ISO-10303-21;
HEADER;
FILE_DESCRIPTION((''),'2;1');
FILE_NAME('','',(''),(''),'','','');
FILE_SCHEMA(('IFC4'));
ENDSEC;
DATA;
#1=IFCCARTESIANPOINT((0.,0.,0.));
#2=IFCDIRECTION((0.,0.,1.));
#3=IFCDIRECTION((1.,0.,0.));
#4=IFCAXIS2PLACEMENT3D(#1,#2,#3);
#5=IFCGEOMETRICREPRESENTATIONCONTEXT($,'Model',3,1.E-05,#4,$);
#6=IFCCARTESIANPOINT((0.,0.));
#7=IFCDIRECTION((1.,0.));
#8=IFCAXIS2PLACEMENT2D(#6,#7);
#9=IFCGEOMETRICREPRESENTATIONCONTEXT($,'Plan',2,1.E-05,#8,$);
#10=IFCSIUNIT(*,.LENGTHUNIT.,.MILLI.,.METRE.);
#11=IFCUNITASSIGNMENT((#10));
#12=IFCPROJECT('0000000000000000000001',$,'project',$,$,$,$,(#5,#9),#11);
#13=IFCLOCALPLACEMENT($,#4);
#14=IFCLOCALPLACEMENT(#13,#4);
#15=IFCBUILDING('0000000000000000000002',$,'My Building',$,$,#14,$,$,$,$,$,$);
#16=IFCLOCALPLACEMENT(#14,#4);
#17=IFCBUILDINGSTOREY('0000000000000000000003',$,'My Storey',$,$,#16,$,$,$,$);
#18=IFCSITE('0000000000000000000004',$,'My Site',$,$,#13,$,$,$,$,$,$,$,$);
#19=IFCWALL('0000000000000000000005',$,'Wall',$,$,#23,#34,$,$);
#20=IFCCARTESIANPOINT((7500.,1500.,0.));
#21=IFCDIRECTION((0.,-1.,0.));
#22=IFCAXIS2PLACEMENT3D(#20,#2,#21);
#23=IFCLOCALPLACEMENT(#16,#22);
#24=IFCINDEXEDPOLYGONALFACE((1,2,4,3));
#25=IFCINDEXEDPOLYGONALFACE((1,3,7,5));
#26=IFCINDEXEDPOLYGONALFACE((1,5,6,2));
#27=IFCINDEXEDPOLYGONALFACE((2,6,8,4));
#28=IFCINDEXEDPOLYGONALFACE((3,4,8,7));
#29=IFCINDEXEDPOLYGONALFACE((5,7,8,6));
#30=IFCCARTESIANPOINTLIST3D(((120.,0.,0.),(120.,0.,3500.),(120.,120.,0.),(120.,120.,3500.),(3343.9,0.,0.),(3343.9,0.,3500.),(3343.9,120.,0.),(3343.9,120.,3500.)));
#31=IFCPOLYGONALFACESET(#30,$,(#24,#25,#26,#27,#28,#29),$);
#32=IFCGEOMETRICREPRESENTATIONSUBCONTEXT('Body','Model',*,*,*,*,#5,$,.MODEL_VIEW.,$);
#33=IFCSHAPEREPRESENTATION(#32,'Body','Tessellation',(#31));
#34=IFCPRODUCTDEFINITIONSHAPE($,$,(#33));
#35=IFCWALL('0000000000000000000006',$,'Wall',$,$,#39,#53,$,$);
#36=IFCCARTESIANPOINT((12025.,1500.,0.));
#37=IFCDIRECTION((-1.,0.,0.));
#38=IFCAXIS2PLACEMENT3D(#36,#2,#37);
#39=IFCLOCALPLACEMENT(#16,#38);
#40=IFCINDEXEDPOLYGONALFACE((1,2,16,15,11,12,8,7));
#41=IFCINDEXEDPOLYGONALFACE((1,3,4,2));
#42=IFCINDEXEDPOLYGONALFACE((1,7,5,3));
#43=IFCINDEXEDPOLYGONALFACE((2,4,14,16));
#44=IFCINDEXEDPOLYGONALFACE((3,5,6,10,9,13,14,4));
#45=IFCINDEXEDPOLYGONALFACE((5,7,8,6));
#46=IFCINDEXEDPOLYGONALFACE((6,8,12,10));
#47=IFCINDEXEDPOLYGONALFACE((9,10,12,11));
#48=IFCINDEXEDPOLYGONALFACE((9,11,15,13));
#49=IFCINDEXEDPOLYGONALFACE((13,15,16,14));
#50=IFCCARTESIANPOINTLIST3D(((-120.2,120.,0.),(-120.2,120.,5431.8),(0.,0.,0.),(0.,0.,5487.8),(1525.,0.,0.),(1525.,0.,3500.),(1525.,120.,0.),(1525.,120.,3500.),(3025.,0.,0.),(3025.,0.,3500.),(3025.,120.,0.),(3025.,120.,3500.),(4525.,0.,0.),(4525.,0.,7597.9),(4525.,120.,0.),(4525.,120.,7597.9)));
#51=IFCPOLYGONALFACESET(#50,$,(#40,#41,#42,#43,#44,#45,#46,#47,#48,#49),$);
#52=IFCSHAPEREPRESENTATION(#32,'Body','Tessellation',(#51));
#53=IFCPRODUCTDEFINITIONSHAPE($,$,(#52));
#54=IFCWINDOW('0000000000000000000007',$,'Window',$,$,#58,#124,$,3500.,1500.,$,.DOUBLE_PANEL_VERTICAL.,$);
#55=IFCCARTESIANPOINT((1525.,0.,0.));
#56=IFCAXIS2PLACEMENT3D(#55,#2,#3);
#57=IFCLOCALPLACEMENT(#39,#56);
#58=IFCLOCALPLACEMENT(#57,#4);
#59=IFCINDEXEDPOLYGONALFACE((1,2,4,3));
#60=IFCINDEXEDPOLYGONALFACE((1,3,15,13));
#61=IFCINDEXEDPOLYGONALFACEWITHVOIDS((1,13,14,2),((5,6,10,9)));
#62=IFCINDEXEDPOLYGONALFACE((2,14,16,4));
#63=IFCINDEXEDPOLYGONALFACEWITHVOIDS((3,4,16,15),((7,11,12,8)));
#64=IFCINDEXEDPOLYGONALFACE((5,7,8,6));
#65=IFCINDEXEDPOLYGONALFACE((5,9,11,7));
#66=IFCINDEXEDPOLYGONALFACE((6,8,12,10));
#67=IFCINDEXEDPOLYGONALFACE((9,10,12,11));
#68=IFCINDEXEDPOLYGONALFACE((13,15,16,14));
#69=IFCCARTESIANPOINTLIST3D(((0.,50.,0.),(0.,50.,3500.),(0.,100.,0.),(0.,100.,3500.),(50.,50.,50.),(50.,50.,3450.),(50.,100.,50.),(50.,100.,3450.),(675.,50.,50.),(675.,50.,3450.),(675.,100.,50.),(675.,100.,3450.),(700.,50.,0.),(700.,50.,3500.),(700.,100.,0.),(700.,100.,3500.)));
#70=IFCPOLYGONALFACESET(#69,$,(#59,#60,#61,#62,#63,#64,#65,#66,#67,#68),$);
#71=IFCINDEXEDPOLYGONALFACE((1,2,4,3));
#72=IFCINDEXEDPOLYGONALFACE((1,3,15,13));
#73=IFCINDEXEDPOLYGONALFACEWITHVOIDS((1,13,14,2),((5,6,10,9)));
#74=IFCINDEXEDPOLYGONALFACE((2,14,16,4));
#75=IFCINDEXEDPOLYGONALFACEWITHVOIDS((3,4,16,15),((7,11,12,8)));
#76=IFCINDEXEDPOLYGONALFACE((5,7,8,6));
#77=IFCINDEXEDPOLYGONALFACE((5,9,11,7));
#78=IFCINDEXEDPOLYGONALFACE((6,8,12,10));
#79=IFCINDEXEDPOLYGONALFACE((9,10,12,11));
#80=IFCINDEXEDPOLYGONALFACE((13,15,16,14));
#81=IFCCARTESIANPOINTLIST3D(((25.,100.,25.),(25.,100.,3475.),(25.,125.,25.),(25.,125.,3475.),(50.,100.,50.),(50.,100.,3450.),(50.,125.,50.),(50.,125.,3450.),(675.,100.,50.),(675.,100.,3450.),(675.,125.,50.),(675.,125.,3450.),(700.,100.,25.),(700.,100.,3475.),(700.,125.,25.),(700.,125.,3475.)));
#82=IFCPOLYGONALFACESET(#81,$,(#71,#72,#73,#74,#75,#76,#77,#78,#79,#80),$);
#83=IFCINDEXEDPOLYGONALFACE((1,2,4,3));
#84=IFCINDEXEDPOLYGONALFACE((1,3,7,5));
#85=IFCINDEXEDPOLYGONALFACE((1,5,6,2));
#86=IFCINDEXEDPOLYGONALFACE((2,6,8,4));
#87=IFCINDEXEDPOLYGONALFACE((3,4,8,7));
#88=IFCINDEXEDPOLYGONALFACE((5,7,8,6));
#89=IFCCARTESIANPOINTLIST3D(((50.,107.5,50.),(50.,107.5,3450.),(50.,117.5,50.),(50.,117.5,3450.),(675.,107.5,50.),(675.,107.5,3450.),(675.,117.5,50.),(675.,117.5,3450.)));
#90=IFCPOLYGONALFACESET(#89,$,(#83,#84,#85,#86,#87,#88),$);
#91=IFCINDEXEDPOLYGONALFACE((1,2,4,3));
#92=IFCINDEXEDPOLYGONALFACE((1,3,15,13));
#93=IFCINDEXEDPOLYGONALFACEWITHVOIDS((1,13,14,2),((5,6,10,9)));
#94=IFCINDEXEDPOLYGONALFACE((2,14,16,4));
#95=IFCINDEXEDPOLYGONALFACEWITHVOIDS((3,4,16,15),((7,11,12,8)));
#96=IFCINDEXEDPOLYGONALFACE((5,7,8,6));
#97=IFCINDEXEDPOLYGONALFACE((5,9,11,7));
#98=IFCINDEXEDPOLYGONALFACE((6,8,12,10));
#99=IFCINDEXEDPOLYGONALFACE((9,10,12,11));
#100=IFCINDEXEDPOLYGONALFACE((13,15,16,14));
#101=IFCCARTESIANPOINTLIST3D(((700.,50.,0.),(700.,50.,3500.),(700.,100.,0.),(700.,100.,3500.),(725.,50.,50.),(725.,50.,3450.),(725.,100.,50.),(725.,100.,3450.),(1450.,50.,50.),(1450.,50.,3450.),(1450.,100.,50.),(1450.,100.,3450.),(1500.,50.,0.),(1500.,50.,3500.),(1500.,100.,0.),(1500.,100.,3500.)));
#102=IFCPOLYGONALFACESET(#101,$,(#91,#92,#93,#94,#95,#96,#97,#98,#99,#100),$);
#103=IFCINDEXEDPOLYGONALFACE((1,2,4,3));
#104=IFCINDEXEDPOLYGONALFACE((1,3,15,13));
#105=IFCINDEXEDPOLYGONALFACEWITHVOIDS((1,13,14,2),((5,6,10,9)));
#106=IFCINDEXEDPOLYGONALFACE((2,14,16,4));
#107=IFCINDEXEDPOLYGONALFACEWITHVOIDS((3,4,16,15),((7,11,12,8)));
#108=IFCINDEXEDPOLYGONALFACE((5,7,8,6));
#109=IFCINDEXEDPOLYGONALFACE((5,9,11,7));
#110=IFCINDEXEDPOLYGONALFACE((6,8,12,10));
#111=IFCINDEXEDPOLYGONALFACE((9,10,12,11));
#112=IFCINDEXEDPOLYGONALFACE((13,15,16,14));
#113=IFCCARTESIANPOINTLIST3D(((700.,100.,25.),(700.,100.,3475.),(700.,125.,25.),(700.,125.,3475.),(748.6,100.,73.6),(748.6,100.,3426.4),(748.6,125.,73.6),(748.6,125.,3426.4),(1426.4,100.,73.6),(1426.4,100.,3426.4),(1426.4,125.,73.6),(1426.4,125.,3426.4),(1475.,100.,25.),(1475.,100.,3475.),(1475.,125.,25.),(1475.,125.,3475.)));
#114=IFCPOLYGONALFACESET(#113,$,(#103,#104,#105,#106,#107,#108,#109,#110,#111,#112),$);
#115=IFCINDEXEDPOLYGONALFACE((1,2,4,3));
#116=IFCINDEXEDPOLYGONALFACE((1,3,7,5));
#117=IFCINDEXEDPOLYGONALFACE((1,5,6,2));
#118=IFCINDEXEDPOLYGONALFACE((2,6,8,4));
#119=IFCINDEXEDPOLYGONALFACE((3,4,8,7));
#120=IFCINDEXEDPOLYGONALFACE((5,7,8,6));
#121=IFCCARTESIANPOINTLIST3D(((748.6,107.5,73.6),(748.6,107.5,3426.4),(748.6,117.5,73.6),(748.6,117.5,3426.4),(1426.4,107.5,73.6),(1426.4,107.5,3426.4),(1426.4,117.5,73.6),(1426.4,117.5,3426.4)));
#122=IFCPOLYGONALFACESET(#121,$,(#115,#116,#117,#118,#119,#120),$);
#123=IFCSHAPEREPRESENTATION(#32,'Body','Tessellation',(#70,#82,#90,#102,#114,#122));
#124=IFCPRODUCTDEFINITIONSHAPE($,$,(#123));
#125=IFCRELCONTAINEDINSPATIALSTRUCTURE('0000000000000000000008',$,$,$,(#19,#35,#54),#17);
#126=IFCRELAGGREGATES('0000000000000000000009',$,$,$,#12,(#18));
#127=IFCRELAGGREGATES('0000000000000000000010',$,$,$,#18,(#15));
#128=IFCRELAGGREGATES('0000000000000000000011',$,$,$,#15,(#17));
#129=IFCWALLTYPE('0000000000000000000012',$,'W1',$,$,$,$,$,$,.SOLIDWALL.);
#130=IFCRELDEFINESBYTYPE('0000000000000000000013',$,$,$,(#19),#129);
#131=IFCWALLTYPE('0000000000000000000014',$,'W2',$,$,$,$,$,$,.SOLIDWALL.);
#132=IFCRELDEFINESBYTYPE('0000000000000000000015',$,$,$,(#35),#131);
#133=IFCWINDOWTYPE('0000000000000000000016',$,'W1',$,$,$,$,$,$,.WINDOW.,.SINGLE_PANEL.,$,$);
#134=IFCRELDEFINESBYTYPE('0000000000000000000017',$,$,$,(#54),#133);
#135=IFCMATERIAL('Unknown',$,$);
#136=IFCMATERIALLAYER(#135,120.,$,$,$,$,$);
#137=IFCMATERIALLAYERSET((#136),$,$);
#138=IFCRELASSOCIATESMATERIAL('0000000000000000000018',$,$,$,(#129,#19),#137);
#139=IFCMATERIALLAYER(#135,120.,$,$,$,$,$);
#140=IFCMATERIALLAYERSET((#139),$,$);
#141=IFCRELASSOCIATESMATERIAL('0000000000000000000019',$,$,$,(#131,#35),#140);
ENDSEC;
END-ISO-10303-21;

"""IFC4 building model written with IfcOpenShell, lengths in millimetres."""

from ifc_helpers import new_model, entity, si_unit, frame, origin_with_axes, origin_2d_with_axis, place, context, subcontext, project, spatial, line, indexed_curve, outline, extrude, shape, source, transform, mapped, material, layer, layer_set, layer_usage, type_object, type_shapes, element, fill, save


model = new_model("IFC4")

# Units and contexts
model_context = context("Model", 3, precision=1e-05, world=origin_with_axes())
plan_context = context("Plan", 2, precision=1e-05, world=origin_2d_with_axis())
body_context_1 = subcontext(model_context, "Body", "Model", "MODEL_VIEW")
body_context_2 = subcontext(plan_context, "Body", "Plan", "PLAN_VIEW")
ifc_project = project(units=[si_unit("LENGTHUNIT", "METRE", prefix="MILLI")], contexts=[model_context, plan_context])

# Site, building, storey
site_placement = place(None, origin_with_axes())
site = spatial("IfcSite", under=ifc_project, at=site_placement, Name="My Site")
building_placement = place(site_placement, origin_with_axes())
building = spatial("IfcBuilding", under=site, at=building_placement, Name="My Building")
storey_placement = place(building_placement, origin_with_axes())
storey = spatial("IfcBuildingStorey", under=building, at=storey_placement, Name="My Storey")

# Shared definitions
ifc_material = material(Name="Unknown")

# Wall
ifc_layer_1 = layer(ifc_material, 120.0)
ifc_layer_set_1 = layer_set([ifc_layer_1])
wall_type_1 = type_object("IfcWallType", Name="W1", PredefinedType="SOLIDWALL", material=ifc_layer_set_1)
ifc_layer_usage_1 = layer_usage(ifc_layer_set_1, "AXIS2", "POSITIVE", 0.0)
wall_1_placement = place(storey_placement, frame((7500.0, 1500.0, 0.0), z_axis=(0.0, 0.0, 1.0), x_axis=(0.0, -1.0, 0.0)))
element("IfcWall", 1, at=wall_1_placement, inside=storey, type_object=wall_type_1, material=ifc_layer_usage_1, Name="Wall", context=body_context_1, shape_type="SweptSolid", body=[
    extrude(outline(indexed_curve([(120.0, 0.0), (120.0, 120.0), (3343.9, 120.0), (3343.9, 0.0)], segments=[line(1, 2, 3, 4, 1)])), origin_with_axes(), (0.0, 0.0, 1.0), 3500.0),
])

# Wall, openings, window
ifc_layer_2 = layer(ifc_material, 120.0)
ifc_layer_set_2 = layer_set([ifc_layer_2])
ifc_layer_usage_2 = layer_usage(ifc_layer_set_2, "AXIS2", "POSITIVE", 0.0)
wall_type_2 = type_object("IfcWallType", Name="W2", PredefinedType="SOLIDWALL", material=ifc_layer_set_2)
wall_2_placement = place(storey_placement, frame((12025.0, 1500.0, 0.0), z_axis=(0.0, 0.0, 1.0), x_axis=(-1.0, 0.0, 0.0)))
wall_2 = element("IfcWall", 2, at=wall_2_placement, inside=storey, type_object=wall_type_2, material=ifc_layer_usage_2, Name="Wall", context=body_context_1, shape_type="SweptSolid", body=[
    extrude(outline(indexed_curve([(0.0, 0.0), (-120.2, 120.0), (4525.0, 120.0), (4525.0, 0.0)], segments=[line(1, 2, 3, 4, 1)])), origin_with_axes(), (0.0, 0.0, 1.0), 9000.0),
])
shared_shape_1 = source(origin_with_axes(), body_context_1, "Body", "SweptSolid", [
    extrude(outline(indexed_curve([(0.0, 0.0), (1500.0, 0.0), (1500.0, 3500.0), (0.0, 3500.0)], segments=[line(1, 2, 3, 4, 1)])), frame((0.0, -600.0, 0.0), z_axis=(0.0, -1.0, 0.0), x_axis=(1.0, 0.0, 0.0)), (0.0, 0.0, -1.0), 1200.0),
])
opening_1_placement = place(wall_2_placement, frame((1525.0, 0.0, 0.0), z_axis=(0.0, 0.0, 1.0), x_axis=(1.0, 0.0, 0.0)))
opening_1 = element("IfcOpeningElement", 3, at=opening_1_placement, cuts=wall_2, PredefinedType="OPENING", context=body_context_1, shape_type="MappedRepresentation", body=[
    mapped(shared_shape_1, transform((0.0, 0.0, 0.0), x_axis=(1.0, 0.0, 0.0), y_axis=(0.0, 1.0, 0.0), z_axis=(0.0, 0.0, 1.0), scale=1.0)),
])
opening_2_placement = place(wall_2_placement, frame((534.9, -241.1, 8957.2), z_axis=(0.0, 0.0, 1.0), x_axis=(-1.0, 0.0, 0.0)))
element("IfcOpeningElement", 4, at=opening_2_placement, cuts=wall_2, PredefinedType="OPENING", context=body_context_1, shape_type="SweptSolid", body=[
    extrude(outline(indexed_curve([(-655.1, 3525.4), (3990.1, 1359.3), (3990.1, -42.8), (-655.1, -42.8), (-655.1, 3525.4)])), frame((0.0, 0.0, 0.0), z_axis=(0.0, -1.0, 0.0), x_axis=(-1.0, 0.0, 0.0)), (0.0, 0.0, 1.0), 500.0),
])
window_type_1 = type_object("IfcWindowType", Name="W1", PartitioningType="SINGLE_PANEL", PredefinedType="WINDOW")
shared_shape_2 = source(origin_with_axes(), body_context_1, "Body", "SweptSolid", [
    extrude(outline(indexed_curve([(0.0, 0.0), (700.0, 0.0), (700.0, 3500.0), (0.0, 3500.0)], segments=[line(1, 2, 3, 4, 1)]), holes=[indexed_curve([(50.0, 50.0), (675.0, 50.0), (675.0, 3450.0), (50.0, 3450.0)], segments=[line(1, 2, 3, 4, 1)])]), frame((0.0, 50.0, 0.0), z_axis=(0.0, -1.0, 0.0), x_axis=(1.0, 0.0, 0.0)), (0.0, 0.0, -1.0), 50.0),
    extrude(outline(indexed_curve([(0.0, 0.0), (675.0, 0.0), (675.0, 3450.0), (0.0, 3450.0)], segments=[line(1, 2, 3, 4, 1)]), holes=[indexed_curve([(25.0, 25.0), (650.0, 25.0), (650.0, 3425.0), (25.0, 3425.0)], segments=[line(1, 2, 3, 4, 1)])]), frame((25.0, 100.0, 25.0), z_axis=(0.0, -1.0, 0.0), x_axis=(1.0, 0.0, 0.0)), (0.0, 0.0, -1.0), 25.0),
    extrude(outline(indexed_curve([(25.0, 25.0), (650.0, 25.0), (650.0, 3425.0), (25.0, 3425.0)], segments=[line(1, 2, 3, 4, 1)])), frame((25.0, 107.5, 25.0), z_axis=(0.0, -1.0, 0.0), x_axis=(1.0, 0.0, 0.0)), (0.0, 0.0, -1.0), 10.0),
    extrude(outline(indexed_curve([(0.0, 0.0), (800.0, 0.0), (800.0, 3500.0), (0.0, 3500.0)], segments=[line(1, 2, 3, 4, 1)]), holes=[indexed_curve([(25.0, 50.0), (750.0, 50.0), (750.0, 3450.0), (25.0, 3450.0)], segments=[line(1, 2, 3, 4, 1)])]), frame((700.0, 50.0, 0.0), z_axis=(0.0, -1.0, 0.0), x_axis=(1.0, 0.0, 0.0)), (0.0, 0.0, -1.0), 50.0),
    extrude(outline(indexed_curve([(0.0, 0.0), (775.0, 0.0), (775.0, 3450.0), (0.0, 3450.0)], segments=[line(1, 2, 3, 4, 1)]), holes=[indexed_curve([(48.6, 48.6), (726.4, 48.6), (726.4, 3401.4), (48.6, 3401.4)], segments=[line(1, 2, 3, 4, 1)])]), frame((700.0, 100.0, 25.0), z_axis=(0.0, -1.0, 0.0), x_axis=(1.0, 0.0, 0.0)), (0.0, 0.0, -1.0), 25.0),
    extrude(outline(indexed_curve([(48.6, 48.6), (726.4, 48.6), (726.4, 3401.4), (48.6, 3401.4)], segments=[line(1, 2, 3, 4, 1)])), frame((700.0, 107.5, 25.0), z_axis=(0.0, -1.0, 0.0), x_axis=(1.0, 0.0, 0.0)), (0.0, 0.0, -1.0), 10.0),
])
shared_shape_3 = source(origin_with_axes(), body_context_2, "Body", "Curve2D", [
    entity("IfcIndexedPolyCurve", entity("IfcCartesianPointList2D", [[50.0, 50.0], [675.0, 50.0]])),
    entity("IfcIndexedPolyCurve", entity("IfcCartesianPointList2D", [[0.0, 100.0], [50.0, 100.0], [50.0, 50.0], [0.0, 50.0]]), [entity("IfcLineIndex", [1, 2, 3, 4, 1])]),
    entity("IfcIndexedPolyCurve", entity("IfcCartesianPointList2D", [[700.0, 100.0], [675.0, 100.0], [675.0, 50.0], [700.0, 50.0]])),
    entity("IfcIndexedPolyCurve", entity("IfcCartesianPointList2D", [[25.0, 100.0], [50.0, 100.0], [50.0, 125.0], [25.0, 125.0]]), [entity("IfcLineIndex", [1, 2, 3, 4, 1])]),
    entity("IfcIndexedPolyCurve", entity("IfcCartesianPointList2D", [[700.0, 100.0], [675.0, 100.0], [675.0, 125.0], [700.0, 125.0]]), [entity("IfcLineIndex", [1, 2, 3, 4, 1])]),
    entity("IfcIndexedPolyCurve", entity("IfcCartesianPointList2D", [[50.0, 100.0], [675.0, 100.0]])),
    entity("IfcIndexedPolyCurve", entity("IfcCartesianPointList2D", [[50.0, 125.0], [675.0, 125.0]])),
    entity("IfcIndexedPolyCurve", entity("IfcCartesianPointList2D", [[50.0, 112.5], [675.0, 112.5]])),
    entity("IfcIndexedPolyCurve", entity("IfcCartesianPointList2D", [[725.0, 50.0], [1450.0, 50.0]])),
    entity("IfcIndexedPolyCurve", entity("IfcCartesianPointList2D", [[700.0, 100.0], [725.0, 100.0], [725.0, 50.0], [700.0, 50.0]])),
    entity("IfcIndexedPolyCurve", entity("IfcCartesianPointList2D", [[1500.0, 100.0], [1450.0, 100.0], [1450.0, 50.0], [1500.0, 50.0]]), [entity("IfcLineIndex", [1, 2, 3, 4, 1])]),
    entity("IfcIndexedPolyCurve", entity("IfcCartesianPointList2D", [[700.0, 100.0], [748.6, 100.0], [748.6, 125.0], [700.0, 125.0]]), [entity("IfcLineIndex", [1, 2, 3, 4, 1])]),
    entity("IfcIndexedPolyCurve", entity("IfcCartesianPointList2D", [[1475.0, 100.0], [1426.4, 100.0], [1426.4, 125.0], [1475.0, 125.0]]), [entity("IfcLineIndex", [1, 2, 3, 4, 1])]),
    entity("IfcIndexedPolyCurve", entity("IfcCartesianPointList2D", [[748.6, 100.0], [1426.4, 100.0]])),
    entity("IfcIndexedPolyCurve", entity("IfcCartesianPointList2D", [[748.6, 125.0], [1426.4, 125.0]])),
    entity("IfcIndexedPolyCurve", entity("IfcCartesianPointList2D", [[748.6, 112.5], [1426.4, 112.5]])),
])
type_shapes(window_type_1, [shared_shape_2, shared_shape_3])
window_1_placement = place(opening_1_placement, frame((0.0, 0.0, 0.0), z_axis=(0.0, 0.0, 1.0), x_axis=(1.0, 0.0, 0.0)))
window_1 = element("IfcWindow", 5, at=window_1_placement, inside=storey, type_object=window_type_1, Name="Window", OverallHeight=3500.0, OverallWidth=1500.0, PartitioningType="DOUBLE_PANEL_VERTICAL", shapes=[
    shape(body_context_1, "Body", "MappedRepresentation", [mapped(shared_shape_2, transform((0.0, 0.0, 0.0), x_axis=(1.0, 0.0, 0.0), y_axis=(0.0, 1.0, 0.0), z_axis=(0.0, 0.0, 1.0), scale=1.0))]),
    shape(body_context_2, "Body", "MappedRepresentation", [mapped(shared_shape_3, transform((0.0, 0.0, 0.0), x_axis=(1.0, 0.0, 0.0), y_axis=(0.0, 1.0, 0.0), z_axis=(0.0, 0.0, 1.0), scale=1.0))]),
])
fill(opening_1, window_1)

save(model, "model.ifc")
